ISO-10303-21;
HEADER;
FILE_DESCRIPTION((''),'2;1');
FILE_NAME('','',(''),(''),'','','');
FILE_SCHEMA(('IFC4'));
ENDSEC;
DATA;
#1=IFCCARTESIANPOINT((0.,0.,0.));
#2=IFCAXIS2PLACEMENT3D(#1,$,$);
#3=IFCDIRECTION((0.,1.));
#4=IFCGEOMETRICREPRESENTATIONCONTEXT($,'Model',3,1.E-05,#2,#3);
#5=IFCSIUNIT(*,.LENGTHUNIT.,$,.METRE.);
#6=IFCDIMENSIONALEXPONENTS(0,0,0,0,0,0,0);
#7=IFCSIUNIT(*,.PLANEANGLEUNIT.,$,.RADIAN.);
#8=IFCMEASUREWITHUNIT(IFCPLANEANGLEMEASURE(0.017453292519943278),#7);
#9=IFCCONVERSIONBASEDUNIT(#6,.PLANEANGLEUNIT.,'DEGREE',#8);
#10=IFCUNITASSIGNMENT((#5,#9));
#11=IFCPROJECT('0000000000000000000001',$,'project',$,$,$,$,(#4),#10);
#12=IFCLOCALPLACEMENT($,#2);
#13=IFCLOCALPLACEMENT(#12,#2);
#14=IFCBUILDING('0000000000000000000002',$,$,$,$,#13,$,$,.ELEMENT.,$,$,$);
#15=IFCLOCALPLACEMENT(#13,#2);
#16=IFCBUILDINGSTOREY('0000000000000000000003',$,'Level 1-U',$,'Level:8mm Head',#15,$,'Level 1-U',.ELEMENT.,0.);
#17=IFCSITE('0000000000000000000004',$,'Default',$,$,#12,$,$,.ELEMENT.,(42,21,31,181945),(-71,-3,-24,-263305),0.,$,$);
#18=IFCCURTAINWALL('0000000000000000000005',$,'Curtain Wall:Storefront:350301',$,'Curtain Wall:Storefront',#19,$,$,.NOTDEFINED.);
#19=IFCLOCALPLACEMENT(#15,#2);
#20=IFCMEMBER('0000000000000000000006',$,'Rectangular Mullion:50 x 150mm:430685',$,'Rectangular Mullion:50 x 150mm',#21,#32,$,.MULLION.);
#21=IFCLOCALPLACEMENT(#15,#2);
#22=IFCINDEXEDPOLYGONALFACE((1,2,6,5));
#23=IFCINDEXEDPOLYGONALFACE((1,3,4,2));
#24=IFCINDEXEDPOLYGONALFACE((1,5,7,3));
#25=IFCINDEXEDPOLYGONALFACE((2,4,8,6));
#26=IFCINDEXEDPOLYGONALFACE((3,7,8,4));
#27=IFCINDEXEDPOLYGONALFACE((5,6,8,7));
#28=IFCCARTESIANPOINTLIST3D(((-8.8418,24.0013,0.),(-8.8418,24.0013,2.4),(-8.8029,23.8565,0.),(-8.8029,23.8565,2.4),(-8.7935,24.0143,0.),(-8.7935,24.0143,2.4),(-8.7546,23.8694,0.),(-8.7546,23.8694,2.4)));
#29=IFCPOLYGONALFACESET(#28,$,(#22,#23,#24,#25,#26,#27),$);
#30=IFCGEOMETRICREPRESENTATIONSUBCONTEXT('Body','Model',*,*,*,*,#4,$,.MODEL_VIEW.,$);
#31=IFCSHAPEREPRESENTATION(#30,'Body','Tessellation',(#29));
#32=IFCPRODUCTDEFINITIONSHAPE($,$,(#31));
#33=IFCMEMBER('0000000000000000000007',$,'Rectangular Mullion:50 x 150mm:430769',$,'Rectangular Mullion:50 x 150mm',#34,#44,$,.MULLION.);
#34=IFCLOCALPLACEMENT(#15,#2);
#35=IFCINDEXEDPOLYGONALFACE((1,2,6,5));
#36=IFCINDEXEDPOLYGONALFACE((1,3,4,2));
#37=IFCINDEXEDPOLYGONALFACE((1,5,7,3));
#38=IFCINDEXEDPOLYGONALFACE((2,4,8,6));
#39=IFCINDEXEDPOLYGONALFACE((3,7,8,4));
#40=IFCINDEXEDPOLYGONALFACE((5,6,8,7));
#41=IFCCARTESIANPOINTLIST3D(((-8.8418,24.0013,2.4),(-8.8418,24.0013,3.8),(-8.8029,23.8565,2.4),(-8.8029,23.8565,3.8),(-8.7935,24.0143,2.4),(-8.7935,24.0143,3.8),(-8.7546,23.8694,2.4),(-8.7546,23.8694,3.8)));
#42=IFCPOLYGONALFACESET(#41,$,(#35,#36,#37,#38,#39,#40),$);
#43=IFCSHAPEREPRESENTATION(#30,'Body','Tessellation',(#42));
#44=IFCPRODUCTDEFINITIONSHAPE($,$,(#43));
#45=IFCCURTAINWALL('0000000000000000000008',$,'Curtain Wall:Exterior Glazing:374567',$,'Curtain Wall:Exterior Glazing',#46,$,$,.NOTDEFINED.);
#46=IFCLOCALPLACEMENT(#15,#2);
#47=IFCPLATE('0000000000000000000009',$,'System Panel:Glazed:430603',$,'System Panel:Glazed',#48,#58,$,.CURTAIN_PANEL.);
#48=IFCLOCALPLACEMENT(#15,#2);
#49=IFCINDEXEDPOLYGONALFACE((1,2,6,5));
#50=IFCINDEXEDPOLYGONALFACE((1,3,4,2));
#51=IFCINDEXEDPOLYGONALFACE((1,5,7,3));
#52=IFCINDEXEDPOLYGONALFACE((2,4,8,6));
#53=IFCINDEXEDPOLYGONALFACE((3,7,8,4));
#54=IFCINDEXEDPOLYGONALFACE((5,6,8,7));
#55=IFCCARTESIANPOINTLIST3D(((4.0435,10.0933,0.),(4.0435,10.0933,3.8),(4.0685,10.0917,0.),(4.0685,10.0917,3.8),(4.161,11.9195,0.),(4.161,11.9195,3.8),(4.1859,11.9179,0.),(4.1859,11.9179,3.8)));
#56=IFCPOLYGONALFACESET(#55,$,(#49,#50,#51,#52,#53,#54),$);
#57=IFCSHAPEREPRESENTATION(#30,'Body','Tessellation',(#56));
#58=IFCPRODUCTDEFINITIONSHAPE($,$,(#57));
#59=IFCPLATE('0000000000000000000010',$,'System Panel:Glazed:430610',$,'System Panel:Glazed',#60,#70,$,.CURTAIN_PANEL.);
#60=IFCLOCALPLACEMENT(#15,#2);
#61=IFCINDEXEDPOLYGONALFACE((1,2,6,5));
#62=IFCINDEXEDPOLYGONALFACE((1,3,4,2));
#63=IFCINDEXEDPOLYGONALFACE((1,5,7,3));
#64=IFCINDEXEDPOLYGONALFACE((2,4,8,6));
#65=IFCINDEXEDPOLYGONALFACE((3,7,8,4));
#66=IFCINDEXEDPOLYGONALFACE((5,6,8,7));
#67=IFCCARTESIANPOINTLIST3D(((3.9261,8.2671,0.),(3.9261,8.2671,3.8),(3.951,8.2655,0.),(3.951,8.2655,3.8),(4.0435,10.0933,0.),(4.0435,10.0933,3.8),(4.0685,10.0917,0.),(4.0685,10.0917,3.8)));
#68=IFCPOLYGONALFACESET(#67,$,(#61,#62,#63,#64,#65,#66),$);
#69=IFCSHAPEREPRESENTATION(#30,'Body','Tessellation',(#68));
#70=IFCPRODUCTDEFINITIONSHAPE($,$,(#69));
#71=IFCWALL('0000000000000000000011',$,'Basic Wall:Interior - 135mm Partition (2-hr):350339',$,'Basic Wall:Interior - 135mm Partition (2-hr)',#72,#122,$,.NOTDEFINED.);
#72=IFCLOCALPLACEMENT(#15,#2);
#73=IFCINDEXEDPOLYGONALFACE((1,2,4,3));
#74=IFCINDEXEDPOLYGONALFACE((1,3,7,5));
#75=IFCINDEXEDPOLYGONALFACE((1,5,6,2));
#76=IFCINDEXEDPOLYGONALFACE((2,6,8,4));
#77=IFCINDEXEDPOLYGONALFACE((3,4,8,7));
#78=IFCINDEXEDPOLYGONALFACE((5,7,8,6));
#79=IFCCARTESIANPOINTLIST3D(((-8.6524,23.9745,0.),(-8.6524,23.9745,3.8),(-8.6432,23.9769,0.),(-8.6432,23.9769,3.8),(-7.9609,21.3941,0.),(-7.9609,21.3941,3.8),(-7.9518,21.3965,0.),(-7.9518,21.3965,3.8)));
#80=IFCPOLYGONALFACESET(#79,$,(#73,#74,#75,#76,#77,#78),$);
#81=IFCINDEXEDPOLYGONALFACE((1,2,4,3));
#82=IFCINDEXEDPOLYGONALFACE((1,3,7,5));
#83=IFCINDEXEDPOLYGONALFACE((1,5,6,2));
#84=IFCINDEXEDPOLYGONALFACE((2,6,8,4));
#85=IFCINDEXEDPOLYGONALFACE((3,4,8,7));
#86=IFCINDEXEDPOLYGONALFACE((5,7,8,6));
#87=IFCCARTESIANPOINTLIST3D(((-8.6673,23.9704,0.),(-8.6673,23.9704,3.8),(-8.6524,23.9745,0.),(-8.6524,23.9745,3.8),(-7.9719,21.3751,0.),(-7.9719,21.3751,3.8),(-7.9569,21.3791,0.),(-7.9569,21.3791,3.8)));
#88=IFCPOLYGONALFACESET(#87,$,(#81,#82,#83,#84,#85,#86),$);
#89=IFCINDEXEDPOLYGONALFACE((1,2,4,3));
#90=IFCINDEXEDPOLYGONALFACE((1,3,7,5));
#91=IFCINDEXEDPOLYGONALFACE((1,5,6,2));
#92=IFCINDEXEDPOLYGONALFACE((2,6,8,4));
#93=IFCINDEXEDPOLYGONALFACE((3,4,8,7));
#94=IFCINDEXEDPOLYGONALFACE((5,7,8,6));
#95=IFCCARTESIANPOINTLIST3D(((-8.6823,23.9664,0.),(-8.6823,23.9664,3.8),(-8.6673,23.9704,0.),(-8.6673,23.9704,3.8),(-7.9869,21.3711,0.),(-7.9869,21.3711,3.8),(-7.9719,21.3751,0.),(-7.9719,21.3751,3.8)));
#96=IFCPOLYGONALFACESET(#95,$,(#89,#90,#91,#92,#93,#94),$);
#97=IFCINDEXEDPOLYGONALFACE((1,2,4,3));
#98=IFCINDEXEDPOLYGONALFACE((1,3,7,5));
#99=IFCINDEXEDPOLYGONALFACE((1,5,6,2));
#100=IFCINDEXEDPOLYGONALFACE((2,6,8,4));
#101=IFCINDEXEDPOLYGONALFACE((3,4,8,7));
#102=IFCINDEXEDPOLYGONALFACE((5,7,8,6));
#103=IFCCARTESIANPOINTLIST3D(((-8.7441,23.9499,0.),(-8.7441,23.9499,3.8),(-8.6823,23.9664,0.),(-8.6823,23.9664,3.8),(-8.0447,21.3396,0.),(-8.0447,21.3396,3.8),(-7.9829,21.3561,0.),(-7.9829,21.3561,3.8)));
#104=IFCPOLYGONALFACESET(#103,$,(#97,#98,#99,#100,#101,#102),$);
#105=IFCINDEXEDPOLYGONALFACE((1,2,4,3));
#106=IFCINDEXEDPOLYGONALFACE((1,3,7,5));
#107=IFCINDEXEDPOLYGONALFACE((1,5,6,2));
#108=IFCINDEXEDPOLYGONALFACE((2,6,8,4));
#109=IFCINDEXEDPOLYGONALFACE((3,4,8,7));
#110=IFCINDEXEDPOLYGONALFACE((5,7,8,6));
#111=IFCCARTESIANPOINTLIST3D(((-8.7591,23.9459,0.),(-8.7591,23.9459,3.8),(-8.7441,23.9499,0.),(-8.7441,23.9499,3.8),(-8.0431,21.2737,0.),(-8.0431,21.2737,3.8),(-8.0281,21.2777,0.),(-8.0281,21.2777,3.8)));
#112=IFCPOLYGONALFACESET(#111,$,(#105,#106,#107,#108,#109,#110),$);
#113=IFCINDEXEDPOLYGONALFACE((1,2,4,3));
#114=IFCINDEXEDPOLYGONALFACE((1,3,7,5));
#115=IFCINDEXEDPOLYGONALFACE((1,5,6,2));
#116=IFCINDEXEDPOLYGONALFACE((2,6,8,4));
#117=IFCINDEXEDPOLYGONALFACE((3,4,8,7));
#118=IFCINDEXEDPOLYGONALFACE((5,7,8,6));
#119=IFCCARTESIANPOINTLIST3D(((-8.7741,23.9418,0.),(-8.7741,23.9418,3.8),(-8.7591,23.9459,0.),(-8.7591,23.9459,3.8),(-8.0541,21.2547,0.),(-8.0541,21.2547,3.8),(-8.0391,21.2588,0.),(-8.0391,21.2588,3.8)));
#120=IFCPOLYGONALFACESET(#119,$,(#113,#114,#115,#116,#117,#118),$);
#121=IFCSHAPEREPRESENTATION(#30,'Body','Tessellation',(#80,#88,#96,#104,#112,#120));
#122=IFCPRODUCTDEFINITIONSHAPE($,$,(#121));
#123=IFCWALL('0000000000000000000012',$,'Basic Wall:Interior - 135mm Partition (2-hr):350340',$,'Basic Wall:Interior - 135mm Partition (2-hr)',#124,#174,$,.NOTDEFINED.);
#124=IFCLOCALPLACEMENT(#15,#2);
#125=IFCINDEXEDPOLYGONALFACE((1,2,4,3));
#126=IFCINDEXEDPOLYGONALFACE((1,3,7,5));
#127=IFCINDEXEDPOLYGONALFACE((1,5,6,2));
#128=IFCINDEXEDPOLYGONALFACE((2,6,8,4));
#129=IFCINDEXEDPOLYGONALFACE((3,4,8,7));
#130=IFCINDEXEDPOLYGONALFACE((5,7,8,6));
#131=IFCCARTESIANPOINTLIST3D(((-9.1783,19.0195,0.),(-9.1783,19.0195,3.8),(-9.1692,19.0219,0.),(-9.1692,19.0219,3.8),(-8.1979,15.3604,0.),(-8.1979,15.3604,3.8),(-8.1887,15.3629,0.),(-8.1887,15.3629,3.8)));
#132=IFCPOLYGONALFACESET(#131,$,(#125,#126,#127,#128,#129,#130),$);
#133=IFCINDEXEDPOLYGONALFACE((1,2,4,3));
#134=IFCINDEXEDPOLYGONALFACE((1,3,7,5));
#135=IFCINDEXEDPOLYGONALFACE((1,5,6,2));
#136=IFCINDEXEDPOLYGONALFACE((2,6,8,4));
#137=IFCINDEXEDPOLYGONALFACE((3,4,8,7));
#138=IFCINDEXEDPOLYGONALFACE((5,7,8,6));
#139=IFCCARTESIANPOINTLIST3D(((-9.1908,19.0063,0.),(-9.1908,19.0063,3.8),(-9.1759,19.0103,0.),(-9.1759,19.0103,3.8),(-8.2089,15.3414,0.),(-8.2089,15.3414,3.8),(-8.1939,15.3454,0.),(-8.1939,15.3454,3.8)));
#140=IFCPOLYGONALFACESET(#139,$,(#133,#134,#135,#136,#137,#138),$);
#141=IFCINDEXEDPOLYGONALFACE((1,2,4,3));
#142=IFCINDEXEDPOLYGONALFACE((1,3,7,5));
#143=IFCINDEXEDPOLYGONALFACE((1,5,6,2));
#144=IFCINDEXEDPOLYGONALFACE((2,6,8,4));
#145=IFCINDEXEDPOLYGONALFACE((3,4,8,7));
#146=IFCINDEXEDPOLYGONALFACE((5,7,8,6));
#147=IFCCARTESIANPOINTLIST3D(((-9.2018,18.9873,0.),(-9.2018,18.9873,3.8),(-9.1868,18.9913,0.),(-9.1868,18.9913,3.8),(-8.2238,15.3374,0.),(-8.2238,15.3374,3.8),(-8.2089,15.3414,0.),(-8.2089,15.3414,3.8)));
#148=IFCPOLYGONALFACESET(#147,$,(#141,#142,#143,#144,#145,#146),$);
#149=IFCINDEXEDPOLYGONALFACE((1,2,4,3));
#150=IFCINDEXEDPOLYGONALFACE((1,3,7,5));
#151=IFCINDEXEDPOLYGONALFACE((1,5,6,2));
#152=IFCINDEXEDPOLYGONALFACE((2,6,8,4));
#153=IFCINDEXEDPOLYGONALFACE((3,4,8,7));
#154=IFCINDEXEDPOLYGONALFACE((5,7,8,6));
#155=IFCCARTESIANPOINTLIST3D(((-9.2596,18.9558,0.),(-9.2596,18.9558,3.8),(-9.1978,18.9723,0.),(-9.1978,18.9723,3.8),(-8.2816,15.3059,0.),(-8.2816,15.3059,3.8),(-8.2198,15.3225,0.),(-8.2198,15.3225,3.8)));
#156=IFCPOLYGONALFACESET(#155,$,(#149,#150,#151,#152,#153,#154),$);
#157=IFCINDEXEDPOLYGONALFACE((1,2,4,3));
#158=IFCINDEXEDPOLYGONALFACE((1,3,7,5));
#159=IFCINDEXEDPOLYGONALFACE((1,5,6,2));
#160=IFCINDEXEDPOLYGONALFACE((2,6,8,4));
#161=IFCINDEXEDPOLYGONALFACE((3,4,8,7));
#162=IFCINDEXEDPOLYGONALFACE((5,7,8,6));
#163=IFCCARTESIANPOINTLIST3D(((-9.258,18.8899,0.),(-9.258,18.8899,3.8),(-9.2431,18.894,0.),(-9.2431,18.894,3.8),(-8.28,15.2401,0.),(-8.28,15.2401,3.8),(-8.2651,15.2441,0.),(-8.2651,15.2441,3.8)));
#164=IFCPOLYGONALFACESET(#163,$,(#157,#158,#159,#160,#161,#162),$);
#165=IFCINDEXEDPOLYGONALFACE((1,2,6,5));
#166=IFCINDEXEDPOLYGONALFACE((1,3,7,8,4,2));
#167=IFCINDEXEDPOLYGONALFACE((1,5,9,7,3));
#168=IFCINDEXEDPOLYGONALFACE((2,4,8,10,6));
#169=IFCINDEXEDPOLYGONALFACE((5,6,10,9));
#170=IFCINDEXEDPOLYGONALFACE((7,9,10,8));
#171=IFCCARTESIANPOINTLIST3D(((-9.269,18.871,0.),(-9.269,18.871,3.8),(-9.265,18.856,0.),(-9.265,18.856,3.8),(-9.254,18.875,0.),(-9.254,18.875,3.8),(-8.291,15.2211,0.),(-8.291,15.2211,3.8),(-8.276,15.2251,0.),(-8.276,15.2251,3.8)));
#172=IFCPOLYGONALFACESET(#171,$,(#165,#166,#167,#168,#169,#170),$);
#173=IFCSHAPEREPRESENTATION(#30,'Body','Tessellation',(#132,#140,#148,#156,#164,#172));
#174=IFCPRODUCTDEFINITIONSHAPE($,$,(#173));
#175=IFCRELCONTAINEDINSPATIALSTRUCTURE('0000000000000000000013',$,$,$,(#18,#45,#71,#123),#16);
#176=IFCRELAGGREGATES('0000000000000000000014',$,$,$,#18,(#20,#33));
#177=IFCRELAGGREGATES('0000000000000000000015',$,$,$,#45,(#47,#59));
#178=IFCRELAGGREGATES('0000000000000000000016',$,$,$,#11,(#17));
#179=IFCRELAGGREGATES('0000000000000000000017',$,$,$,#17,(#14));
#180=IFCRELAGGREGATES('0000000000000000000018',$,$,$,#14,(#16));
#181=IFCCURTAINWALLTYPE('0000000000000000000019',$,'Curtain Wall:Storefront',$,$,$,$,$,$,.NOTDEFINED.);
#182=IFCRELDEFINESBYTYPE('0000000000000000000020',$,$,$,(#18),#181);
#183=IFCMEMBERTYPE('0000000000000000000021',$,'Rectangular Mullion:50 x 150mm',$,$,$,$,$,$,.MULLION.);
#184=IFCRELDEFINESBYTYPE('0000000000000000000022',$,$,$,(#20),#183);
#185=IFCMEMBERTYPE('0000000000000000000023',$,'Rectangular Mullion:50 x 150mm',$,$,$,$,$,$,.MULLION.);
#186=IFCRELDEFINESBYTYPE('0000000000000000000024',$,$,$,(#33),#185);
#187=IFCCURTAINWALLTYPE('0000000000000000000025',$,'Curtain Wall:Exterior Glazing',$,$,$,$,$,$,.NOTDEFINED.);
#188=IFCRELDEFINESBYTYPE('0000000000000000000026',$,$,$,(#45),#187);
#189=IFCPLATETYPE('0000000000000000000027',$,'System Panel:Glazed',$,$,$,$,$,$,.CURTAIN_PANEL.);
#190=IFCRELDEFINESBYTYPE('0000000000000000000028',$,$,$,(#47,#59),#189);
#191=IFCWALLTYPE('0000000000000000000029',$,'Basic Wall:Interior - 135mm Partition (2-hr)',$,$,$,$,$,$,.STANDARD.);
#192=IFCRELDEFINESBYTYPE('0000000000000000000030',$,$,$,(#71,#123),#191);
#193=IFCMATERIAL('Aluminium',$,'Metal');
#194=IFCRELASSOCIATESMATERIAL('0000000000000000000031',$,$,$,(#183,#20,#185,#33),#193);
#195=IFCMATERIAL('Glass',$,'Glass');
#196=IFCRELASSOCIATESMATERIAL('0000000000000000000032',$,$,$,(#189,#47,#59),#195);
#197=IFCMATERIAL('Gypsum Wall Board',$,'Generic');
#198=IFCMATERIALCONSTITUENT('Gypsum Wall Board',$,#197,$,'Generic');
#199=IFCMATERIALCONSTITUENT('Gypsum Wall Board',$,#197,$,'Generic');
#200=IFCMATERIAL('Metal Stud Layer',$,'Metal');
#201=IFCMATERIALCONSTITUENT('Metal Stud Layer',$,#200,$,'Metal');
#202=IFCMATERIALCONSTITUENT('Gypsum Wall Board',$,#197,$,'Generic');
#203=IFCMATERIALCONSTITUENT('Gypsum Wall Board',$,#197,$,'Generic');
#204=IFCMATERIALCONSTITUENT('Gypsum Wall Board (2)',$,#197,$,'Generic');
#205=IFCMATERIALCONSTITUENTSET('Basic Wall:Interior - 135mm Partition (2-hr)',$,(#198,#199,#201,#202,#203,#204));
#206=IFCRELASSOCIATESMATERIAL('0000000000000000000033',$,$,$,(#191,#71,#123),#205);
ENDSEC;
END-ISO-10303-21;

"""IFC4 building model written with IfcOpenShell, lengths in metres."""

from ifc_helpers import new_model, entity, si_unit, converted_unit, direction, frame, origin, place, context, subcontext, project, spatial, indexed_curve, outline, extrude, source, transform, mapped, material, constituent, constituent_set, type_object, type_shapes, element, aggregate, save


model = new_model("IFC4")

# Units and contexts
model_context = context("Model", 3, precision=1e-05, world=origin(), true_north=direction((0.0, 1.0)))
body_context = subcontext(model_context, "Body", "Model", "MODEL_VIEW")
ifc_project = project(units=[si_unit("LENGTHUNIT", "METRE"), converted_unit("PLANEANGLEUNIT", "DEGREE", entity("IfcPlaneAngleMeasure", 0.017453292519943278), si_unit("PLANEANGLEUNIT", "RADIAN"), dimensions=[0, 0, 0, 0, 0, 0, 0])], contexts=[model_context])

# Site, building, storey
site_placement = place(None, origin())
site = spatial("IfcSite", under=ifc_project, at=site_placement, Name="Default", CompositionType="ELEMENT", RefLatitude=(42, 21, 31, 181945), RefLongitude=(-71, -3, -24, -263305), RefElevation=0.0)
building_placement = place(site_placement, origin())
building = spatial("IfcBuilding", under=site, at=building_placement, CompositionType="ELEMENT")
storey_placement = place(building_placement, origin())
storey = spatial("IfcBuildingStorey", under=building, at=storey_placement, Name="Level 1-U", ObjectType="Level:8mm Head", LongName="Level 1-U", CompositionType="ELEMENT", Elevation=0.0)

# Curtain wall, members
curtain_wall_type_1 = type_object("IfcCurtainWallType", Name="Curtain Wall:Storefront", PredefinedType="NOTDEFINED")
curtain_wall_1_placement = place(storey_placement, origin())
curtain_wall_1 = element("IfcCurtainWall", 1, at=curtain_wall_1_placement, inside=storey, type_object=curtain_wall_type_1, Name="Curtain Wall:Storefront:350301", ObjectType="Curtain Wall:Storefront", PredefinedType="NOTDEFINED")
ifc_material_1 = material(Name="Aluminium", Category="Metal")
member_type_1 = type_object("IfcMemberType", Name="Rectangular Mullion:50 x 150mm", PredefinedType="MULLION", material=ifc_material_1)
shared_shape_1 = source(origin(), body_context, "Body", "SweptSolid", [
    extrude(outline(indexed_curve([(-0.025, -0.075), (0.025, -0.075), (0.025, 0.075), (-0.025, 0.075), (-0.025, -0.075)], self_intersect=False)), frame((-0.025, 0.0, -2.4), z_axis=(0.0, 0.0, 1.0), x_axis=(-1.0, 0.0, 0.0)), (0.0, 0.0, 1.0), 2.4),
])
type_shapes(member_type_1, [shared_shape_1])
member_1_placement = place(curtain_wall_1_placement, frame((-8.7741, 23.9418, 0.0), z_axis=(0.0, 0.0, -1.0), x_axis=(0.965926, 0.258819, 0.0)))
member_1 = element("IfcMember", 2, at=member_1_placement, type_object=member_type_1, material=ifc_material_1, Name="Rectangular Mullion:50 x 150mm:430685", ObjectType="Rectangular Mullion:50 x 150mm", PredefinedType="MULLION", context=body_context, shape_type="MappedRepresentation", body=[
    mapped(shared_shape_1, transform((0.0, 0.0, 0.0), scale=1.0)),
])
member_type_2 = type_object("IfcMemberType", Name="Rectangular Mullion:50 x 150mm", PredefinedType="MULLION", material=ifc_material_1)
shared_shape_2 = source(origin(), body_context, "Body", "SweptSolid", [
    extrude(outline(indexed_curve([(-0.025, -0.075), (0.025, -0.075), (0.025, 0.075), (-0.025, 0.075), (-0.025, -0.075)], self_intersect=False)), frame((-0.025, 0.0, -1.4), z_axis=(0.0, 0.0, 1.0), x_axis=(-1.0, 0.0, 0.0)), (0.0, 0.0, 1.0), 1.4),
])
type_shapes(member_type_2, [shared_shape_2])
member_2_placement = place(curtain_wall_1_placement, frame((-8.7741, 23.9418, 2.4), z_axis=(0.0, 0.0, -1.0), x_axis=(0.965926, 0.258819, 0.0)))
member_2 = element("IfcMember", 3, at=member_2_placement, type_object=member_type_2, material=ifc_material_1, Name="Rectangular Mullion:50 x 150mm:430769", ObjectType="Rectangular Mullion:50 x 150mm", PredefinedType="MULLION", context=body_context, shape_type="MappedRepresentation", body=[
    mapped(shared_shape_2, transform((0.0, 0.0, 0.0), scale=1.0)),
])
aggregate(curtain_wall_1, [member_1, member_2])

# Curtain wall, plates
curtain_wall_type_2 = type_object("IfcCurtainWallType", Name="Curtain Wall:Exterior Glazing", PredefinedType="NOTDEFINED")
curtain_wall_2_placement = place(storey_placement, origin())
curtain_wall_2 = element("IfcCurtainWall", 4, at=curtain_wall_2_placement, inside=storey, type_object=curtain_wall_type_2, Name="Curtain Wall:Exterior Glazing:374567", ObjectType="Curtain Wall:Exterior Glazing", PredefinedType="NOTDEFINED")
ifc_material_2 = material(Name="Glass", Category="Glass")
plate_type = type_object("IfcPlateType", Name="System Panel:Glazed", PredefinedType="CURTAIN_PANEL", material=ifc_material_2)
shared_shape_3 = source(origin(), body_context, "Body", "SweptSolid", [
    extrude(outline(indexed_curve([(-0.0125, -0.915), (0.0125, -0.915), (0.0125, 0.915), (-0.0125, 0.915), (-0.0125, -0.915)], self_intersect=False)), frame((0.0, 0.037, 0.0), z_axis=(0.0, 0.0, 1.0), x_axis=(0.0, 1.0, 0.0)), (0.0, 0.0, 1.0), 3.8),
])
type_shapes(plate_type, [shared_shape_3])
plate_1_placement = place(curtain_wall_2_placement, frame((4.0778, 11.008, 0.0), z_axis=(0.0, 0.0, 1.0), x_axis=(-0.064186, -0.997938, 0.0)))
plate_1 = element("IfcPlate", 5, at=plate_1_placement, type_object=plate_type, material=ifc_material_2, Name="System Panel:Glazed:430603", ObjectType="System Panel:Glazed", PredefinedType="CURTAIN_PANEL", context=body_context, shape_type="MappedRepresentation", body=[
    mapped(shared_shape_3, transform((0.0, 0.0, 0.0), scale=1.0)),
])
plate_2_placement = place(curtain_wall_2_placement, frame((3.9604, 9.1818, 0.0), z_axis=(0.0, 0.0, 1.0), x_axis=(-0.064186, -0.997938, 0.0)))
plate_2 = element("IfcPlate", 6, at=plate_2_placement, type_object=plate_type, material=ifc_material_2, Name="System Panel:Glazed:430610", ObjectType="System Panel:Glazed", PredefinedType="CURTAIN_PANEL", context=body_context, shape_type="MappedRepresentation", body=[
    mapped(shared_shape_3, transform((0.0, 0.0, 0.0), scale=1.0)),
])
aggregate(curtain_wall_2, [plate_1, plate_2])

# Shared definitions
ifc_material_3 = material(Name="Gypsum Wall Board", Category="Generic")
ifc_constituent_1 = constituent(ifc_material_3, Name="Gypsum Wall Board", Category="Generic")
ifc_constituent_2 = constituent(ifc_material_3, Name="Gypsum Wall Board", Category="Generic")
ifc_material_4 = material(Name="Metal Stud Layer", Category="Metal")
ifc_constituent_3 = constituent(ifc_material_4, Name="Metal Stud Layer", Category="Metal")
ifc_constituent_4 = constituent(ifc_material_3, Name="Gypsum Wall Board", Category="Generic")
ifc_constituent_5 = constituent(ifc_material_3, Name="Gypsum Wall Board", Category="Generic")
ifc_constituent_6 = constituent(ifc_material_3, Name="Gypsum Wall Board (2)", Category="Generic")
ifc_constituent_set_1 = constituent_set(constituents=[ifc_constituent_1, ifc_constituent_2, ifc_constituent_3, ifc_constituent_4, ifc_constituent_5, ifc_constituent_6], Name="Basic Wall:Interior - 135mm Partition (2-hr)")
wall_type = type_object("IfcWallType", Name="Basic Wall:Interior - 135mm Partition (2-hr)", PredefinedType="STANDARD", material=ifc_constituent_set_1)

# Walls
wall_1_placement = place(storey_placement, frame((-8.0172, 21.379, 0.0), z_axis=(0.0, 0.0, 1.0), x_axis=(-0.258819, 0.965926, 0.0)))
element("IfcWall", 7, at=wall_1_placement, inside=storey, type_object=wall_type, material=ifc_constituent_set_1, Name="Basic Wall:Interior - 135mm Partition (2-hr):350339", ObjectType="Basic Wall:Interior - 135mm Partition (2-hr)", PredefinedType="NOTDEFINED", context=body_context, shape_type="SweptSolid", body=[
    extrude(outline(indexed_curve([(-0.0047, -1.3357), (0.0048, -1.3357), (0.0047, 1.3357), (-0.0048, 1.3357), (-0.0047, -1.3357)], self_intersect=False)), frame((1.3357, -0.063, 0.0), z_axis=(0.0, 0.0, 1.0), x_axis=(0.0, 1.0, 0.0)), (0.0, 0.0, 1.0), 3.8),
    extrude(outline(indexed_curve([(-1.3434, -0.0078), (1.3434, -0.0078), (1.3434, 0.0078), (-1.3434, 0.0078), (-1.3434, -0.0078)], self_intersect=False)), frame((1.3279, -0.0505, 0.0)), (0.0, 0.0, 1.0), 3.8),
    extrude(outline(indexed_curve([(-1.3434, -0.0078), (1.3434, -0.0078), (1.3434, 0.0078), (-1.3434, 0.0078), (-1.3434, -0.0078)], self_intersect=False)), frame((1.3279, -0.035, 0.0)), (0.0, 0.0, 1.0), 3.8),
    extrude(outline(indexed_curve([(-1.3512, -0.032), (1.3512, -0.032), (1.3512, 0.032), (-1.3512, 0.032), (-1.3512, -0.032)], self_intersect=False)), frame((1.3202, 0.0048, 0.0)), (0.0, 0.0, 1.0), 3.8),
    extrude(outline(indexed_curve([(-1.3832, -0.0077), (1.3832, -0.0077), (1.3832, 0.0077), (-1.3832, 0.0078), (-1.3832, -0.0077)], self_intersect=False)), frame((1.2882, 0.0445, 0.0)), (0.0, 0.0, 1.0), 3.8),
    extrude(outline(indexed_curve([(-0.0077, -1.3909), (0.0078, -1.3909), (0.0077, 1.3909), (-0.0078, 1.3909), (-0.0077, -1.3909)], self_intersect=False)), frame((1.2804, 0.06, 0.0), z_axis=(0.0, 0.0, 1.0), x_axis=(0.0, -1.0, 0.0)), (0.0, 0.0, 1.0), 3.8),
])
wall_2_placement = place(storey_placement, frame((-8.2542, 15.3453, 0.0), z_axis=(0.0, 0.0, 1.0), x_axis=(-0.258819, 0.965926, 0.0)))
element("IfcWall", 8, at=wall_2_placement, inside=storey, type_object=wall_type, material=ifc_constituent_set_1, Name="Basic Wall:Interior - 135mm Partition (2-hr):350340", ObjectType="Basic Wall:Interior - 135mm Partition (2-hr)", PredefinedType="NOTDEFINED", context=body_context, shape_type="SweptSolid", body=[
    extrude(outline(indexed_curve([(-0.0047, -1.8941), (0.0048, -1.8941), (0.0047, 1.8941), (-0.0048, 1.8941), (-0.0047, -1.8941)], self_intersect=False)), frame((1.8941, -0.063, 0.0), z_axis=(0.0, 0.0, 1.0), x_axis=(0.0, 1.0, 0.0)), (0.0, 0.0, 1.0), 3.8),
    extrude(outline(indexed_curve([(-1.8971, -0.0077), (1.8971, -0.0078), (1.8971, 0.0077), (-1.8971, 0.0078), (-1.8971, -0.0077)], self_intersect=False)), frame((1.8816, -0.0505, 0.0)), (0.0, 0.0, 1.0), 3.8),
    extrude(outline(indexed_curve([(-1.8893, -0.0078), (1.8893, -0.0077), (1.8893, 0.0078), (-1.8893, 0.0077), (-1.8893, -0.0078)], self_intersect=False)), frame((1.8738, -0.035, 0.0)), (0.0, 0.0, 1.0), 3.8),
    extrude(outline(indexed_curve([(-1.8893, -0.032), (1.8893, -0.032), (1.8893, 0.032), (-1.8893, 0.032), (-1.8893, -0.032)], self_intersect=False)), frame((1.8583, 0.0048, 0.0)), (0.0, 0.0, 1.0), 3.8),
    extrude(outline(indexed_curve([(-1.8893, -0.0077), (1.8893, -0.0078), (1.8893, 0.0077), (-1.8893, 0.0078), (-1.8893, -0.0077)], self_intersect=False)), frame((1.7943, 0.0445, 0.0)), (0.0, 0.0, 1.0), 3.8),
    extrude(outline(indexed_curve([(-1.4991, -0.0062), (2.2641, -0.0062), (2.2641, 0.0093), (-1.5146, 0.0093), (-1.5146, -0.0062), (-1.4991, -0.0062)], self_intersect=False)), frame((2.1536, 0.0616, 0.0), z_axis=(0.0, 0.0, 1.0), x_axis=(-1.0, 0.0, 0.0)), (0.0, 0.0, 1.0), 3.8),
])

save(model, "model.ifc")
